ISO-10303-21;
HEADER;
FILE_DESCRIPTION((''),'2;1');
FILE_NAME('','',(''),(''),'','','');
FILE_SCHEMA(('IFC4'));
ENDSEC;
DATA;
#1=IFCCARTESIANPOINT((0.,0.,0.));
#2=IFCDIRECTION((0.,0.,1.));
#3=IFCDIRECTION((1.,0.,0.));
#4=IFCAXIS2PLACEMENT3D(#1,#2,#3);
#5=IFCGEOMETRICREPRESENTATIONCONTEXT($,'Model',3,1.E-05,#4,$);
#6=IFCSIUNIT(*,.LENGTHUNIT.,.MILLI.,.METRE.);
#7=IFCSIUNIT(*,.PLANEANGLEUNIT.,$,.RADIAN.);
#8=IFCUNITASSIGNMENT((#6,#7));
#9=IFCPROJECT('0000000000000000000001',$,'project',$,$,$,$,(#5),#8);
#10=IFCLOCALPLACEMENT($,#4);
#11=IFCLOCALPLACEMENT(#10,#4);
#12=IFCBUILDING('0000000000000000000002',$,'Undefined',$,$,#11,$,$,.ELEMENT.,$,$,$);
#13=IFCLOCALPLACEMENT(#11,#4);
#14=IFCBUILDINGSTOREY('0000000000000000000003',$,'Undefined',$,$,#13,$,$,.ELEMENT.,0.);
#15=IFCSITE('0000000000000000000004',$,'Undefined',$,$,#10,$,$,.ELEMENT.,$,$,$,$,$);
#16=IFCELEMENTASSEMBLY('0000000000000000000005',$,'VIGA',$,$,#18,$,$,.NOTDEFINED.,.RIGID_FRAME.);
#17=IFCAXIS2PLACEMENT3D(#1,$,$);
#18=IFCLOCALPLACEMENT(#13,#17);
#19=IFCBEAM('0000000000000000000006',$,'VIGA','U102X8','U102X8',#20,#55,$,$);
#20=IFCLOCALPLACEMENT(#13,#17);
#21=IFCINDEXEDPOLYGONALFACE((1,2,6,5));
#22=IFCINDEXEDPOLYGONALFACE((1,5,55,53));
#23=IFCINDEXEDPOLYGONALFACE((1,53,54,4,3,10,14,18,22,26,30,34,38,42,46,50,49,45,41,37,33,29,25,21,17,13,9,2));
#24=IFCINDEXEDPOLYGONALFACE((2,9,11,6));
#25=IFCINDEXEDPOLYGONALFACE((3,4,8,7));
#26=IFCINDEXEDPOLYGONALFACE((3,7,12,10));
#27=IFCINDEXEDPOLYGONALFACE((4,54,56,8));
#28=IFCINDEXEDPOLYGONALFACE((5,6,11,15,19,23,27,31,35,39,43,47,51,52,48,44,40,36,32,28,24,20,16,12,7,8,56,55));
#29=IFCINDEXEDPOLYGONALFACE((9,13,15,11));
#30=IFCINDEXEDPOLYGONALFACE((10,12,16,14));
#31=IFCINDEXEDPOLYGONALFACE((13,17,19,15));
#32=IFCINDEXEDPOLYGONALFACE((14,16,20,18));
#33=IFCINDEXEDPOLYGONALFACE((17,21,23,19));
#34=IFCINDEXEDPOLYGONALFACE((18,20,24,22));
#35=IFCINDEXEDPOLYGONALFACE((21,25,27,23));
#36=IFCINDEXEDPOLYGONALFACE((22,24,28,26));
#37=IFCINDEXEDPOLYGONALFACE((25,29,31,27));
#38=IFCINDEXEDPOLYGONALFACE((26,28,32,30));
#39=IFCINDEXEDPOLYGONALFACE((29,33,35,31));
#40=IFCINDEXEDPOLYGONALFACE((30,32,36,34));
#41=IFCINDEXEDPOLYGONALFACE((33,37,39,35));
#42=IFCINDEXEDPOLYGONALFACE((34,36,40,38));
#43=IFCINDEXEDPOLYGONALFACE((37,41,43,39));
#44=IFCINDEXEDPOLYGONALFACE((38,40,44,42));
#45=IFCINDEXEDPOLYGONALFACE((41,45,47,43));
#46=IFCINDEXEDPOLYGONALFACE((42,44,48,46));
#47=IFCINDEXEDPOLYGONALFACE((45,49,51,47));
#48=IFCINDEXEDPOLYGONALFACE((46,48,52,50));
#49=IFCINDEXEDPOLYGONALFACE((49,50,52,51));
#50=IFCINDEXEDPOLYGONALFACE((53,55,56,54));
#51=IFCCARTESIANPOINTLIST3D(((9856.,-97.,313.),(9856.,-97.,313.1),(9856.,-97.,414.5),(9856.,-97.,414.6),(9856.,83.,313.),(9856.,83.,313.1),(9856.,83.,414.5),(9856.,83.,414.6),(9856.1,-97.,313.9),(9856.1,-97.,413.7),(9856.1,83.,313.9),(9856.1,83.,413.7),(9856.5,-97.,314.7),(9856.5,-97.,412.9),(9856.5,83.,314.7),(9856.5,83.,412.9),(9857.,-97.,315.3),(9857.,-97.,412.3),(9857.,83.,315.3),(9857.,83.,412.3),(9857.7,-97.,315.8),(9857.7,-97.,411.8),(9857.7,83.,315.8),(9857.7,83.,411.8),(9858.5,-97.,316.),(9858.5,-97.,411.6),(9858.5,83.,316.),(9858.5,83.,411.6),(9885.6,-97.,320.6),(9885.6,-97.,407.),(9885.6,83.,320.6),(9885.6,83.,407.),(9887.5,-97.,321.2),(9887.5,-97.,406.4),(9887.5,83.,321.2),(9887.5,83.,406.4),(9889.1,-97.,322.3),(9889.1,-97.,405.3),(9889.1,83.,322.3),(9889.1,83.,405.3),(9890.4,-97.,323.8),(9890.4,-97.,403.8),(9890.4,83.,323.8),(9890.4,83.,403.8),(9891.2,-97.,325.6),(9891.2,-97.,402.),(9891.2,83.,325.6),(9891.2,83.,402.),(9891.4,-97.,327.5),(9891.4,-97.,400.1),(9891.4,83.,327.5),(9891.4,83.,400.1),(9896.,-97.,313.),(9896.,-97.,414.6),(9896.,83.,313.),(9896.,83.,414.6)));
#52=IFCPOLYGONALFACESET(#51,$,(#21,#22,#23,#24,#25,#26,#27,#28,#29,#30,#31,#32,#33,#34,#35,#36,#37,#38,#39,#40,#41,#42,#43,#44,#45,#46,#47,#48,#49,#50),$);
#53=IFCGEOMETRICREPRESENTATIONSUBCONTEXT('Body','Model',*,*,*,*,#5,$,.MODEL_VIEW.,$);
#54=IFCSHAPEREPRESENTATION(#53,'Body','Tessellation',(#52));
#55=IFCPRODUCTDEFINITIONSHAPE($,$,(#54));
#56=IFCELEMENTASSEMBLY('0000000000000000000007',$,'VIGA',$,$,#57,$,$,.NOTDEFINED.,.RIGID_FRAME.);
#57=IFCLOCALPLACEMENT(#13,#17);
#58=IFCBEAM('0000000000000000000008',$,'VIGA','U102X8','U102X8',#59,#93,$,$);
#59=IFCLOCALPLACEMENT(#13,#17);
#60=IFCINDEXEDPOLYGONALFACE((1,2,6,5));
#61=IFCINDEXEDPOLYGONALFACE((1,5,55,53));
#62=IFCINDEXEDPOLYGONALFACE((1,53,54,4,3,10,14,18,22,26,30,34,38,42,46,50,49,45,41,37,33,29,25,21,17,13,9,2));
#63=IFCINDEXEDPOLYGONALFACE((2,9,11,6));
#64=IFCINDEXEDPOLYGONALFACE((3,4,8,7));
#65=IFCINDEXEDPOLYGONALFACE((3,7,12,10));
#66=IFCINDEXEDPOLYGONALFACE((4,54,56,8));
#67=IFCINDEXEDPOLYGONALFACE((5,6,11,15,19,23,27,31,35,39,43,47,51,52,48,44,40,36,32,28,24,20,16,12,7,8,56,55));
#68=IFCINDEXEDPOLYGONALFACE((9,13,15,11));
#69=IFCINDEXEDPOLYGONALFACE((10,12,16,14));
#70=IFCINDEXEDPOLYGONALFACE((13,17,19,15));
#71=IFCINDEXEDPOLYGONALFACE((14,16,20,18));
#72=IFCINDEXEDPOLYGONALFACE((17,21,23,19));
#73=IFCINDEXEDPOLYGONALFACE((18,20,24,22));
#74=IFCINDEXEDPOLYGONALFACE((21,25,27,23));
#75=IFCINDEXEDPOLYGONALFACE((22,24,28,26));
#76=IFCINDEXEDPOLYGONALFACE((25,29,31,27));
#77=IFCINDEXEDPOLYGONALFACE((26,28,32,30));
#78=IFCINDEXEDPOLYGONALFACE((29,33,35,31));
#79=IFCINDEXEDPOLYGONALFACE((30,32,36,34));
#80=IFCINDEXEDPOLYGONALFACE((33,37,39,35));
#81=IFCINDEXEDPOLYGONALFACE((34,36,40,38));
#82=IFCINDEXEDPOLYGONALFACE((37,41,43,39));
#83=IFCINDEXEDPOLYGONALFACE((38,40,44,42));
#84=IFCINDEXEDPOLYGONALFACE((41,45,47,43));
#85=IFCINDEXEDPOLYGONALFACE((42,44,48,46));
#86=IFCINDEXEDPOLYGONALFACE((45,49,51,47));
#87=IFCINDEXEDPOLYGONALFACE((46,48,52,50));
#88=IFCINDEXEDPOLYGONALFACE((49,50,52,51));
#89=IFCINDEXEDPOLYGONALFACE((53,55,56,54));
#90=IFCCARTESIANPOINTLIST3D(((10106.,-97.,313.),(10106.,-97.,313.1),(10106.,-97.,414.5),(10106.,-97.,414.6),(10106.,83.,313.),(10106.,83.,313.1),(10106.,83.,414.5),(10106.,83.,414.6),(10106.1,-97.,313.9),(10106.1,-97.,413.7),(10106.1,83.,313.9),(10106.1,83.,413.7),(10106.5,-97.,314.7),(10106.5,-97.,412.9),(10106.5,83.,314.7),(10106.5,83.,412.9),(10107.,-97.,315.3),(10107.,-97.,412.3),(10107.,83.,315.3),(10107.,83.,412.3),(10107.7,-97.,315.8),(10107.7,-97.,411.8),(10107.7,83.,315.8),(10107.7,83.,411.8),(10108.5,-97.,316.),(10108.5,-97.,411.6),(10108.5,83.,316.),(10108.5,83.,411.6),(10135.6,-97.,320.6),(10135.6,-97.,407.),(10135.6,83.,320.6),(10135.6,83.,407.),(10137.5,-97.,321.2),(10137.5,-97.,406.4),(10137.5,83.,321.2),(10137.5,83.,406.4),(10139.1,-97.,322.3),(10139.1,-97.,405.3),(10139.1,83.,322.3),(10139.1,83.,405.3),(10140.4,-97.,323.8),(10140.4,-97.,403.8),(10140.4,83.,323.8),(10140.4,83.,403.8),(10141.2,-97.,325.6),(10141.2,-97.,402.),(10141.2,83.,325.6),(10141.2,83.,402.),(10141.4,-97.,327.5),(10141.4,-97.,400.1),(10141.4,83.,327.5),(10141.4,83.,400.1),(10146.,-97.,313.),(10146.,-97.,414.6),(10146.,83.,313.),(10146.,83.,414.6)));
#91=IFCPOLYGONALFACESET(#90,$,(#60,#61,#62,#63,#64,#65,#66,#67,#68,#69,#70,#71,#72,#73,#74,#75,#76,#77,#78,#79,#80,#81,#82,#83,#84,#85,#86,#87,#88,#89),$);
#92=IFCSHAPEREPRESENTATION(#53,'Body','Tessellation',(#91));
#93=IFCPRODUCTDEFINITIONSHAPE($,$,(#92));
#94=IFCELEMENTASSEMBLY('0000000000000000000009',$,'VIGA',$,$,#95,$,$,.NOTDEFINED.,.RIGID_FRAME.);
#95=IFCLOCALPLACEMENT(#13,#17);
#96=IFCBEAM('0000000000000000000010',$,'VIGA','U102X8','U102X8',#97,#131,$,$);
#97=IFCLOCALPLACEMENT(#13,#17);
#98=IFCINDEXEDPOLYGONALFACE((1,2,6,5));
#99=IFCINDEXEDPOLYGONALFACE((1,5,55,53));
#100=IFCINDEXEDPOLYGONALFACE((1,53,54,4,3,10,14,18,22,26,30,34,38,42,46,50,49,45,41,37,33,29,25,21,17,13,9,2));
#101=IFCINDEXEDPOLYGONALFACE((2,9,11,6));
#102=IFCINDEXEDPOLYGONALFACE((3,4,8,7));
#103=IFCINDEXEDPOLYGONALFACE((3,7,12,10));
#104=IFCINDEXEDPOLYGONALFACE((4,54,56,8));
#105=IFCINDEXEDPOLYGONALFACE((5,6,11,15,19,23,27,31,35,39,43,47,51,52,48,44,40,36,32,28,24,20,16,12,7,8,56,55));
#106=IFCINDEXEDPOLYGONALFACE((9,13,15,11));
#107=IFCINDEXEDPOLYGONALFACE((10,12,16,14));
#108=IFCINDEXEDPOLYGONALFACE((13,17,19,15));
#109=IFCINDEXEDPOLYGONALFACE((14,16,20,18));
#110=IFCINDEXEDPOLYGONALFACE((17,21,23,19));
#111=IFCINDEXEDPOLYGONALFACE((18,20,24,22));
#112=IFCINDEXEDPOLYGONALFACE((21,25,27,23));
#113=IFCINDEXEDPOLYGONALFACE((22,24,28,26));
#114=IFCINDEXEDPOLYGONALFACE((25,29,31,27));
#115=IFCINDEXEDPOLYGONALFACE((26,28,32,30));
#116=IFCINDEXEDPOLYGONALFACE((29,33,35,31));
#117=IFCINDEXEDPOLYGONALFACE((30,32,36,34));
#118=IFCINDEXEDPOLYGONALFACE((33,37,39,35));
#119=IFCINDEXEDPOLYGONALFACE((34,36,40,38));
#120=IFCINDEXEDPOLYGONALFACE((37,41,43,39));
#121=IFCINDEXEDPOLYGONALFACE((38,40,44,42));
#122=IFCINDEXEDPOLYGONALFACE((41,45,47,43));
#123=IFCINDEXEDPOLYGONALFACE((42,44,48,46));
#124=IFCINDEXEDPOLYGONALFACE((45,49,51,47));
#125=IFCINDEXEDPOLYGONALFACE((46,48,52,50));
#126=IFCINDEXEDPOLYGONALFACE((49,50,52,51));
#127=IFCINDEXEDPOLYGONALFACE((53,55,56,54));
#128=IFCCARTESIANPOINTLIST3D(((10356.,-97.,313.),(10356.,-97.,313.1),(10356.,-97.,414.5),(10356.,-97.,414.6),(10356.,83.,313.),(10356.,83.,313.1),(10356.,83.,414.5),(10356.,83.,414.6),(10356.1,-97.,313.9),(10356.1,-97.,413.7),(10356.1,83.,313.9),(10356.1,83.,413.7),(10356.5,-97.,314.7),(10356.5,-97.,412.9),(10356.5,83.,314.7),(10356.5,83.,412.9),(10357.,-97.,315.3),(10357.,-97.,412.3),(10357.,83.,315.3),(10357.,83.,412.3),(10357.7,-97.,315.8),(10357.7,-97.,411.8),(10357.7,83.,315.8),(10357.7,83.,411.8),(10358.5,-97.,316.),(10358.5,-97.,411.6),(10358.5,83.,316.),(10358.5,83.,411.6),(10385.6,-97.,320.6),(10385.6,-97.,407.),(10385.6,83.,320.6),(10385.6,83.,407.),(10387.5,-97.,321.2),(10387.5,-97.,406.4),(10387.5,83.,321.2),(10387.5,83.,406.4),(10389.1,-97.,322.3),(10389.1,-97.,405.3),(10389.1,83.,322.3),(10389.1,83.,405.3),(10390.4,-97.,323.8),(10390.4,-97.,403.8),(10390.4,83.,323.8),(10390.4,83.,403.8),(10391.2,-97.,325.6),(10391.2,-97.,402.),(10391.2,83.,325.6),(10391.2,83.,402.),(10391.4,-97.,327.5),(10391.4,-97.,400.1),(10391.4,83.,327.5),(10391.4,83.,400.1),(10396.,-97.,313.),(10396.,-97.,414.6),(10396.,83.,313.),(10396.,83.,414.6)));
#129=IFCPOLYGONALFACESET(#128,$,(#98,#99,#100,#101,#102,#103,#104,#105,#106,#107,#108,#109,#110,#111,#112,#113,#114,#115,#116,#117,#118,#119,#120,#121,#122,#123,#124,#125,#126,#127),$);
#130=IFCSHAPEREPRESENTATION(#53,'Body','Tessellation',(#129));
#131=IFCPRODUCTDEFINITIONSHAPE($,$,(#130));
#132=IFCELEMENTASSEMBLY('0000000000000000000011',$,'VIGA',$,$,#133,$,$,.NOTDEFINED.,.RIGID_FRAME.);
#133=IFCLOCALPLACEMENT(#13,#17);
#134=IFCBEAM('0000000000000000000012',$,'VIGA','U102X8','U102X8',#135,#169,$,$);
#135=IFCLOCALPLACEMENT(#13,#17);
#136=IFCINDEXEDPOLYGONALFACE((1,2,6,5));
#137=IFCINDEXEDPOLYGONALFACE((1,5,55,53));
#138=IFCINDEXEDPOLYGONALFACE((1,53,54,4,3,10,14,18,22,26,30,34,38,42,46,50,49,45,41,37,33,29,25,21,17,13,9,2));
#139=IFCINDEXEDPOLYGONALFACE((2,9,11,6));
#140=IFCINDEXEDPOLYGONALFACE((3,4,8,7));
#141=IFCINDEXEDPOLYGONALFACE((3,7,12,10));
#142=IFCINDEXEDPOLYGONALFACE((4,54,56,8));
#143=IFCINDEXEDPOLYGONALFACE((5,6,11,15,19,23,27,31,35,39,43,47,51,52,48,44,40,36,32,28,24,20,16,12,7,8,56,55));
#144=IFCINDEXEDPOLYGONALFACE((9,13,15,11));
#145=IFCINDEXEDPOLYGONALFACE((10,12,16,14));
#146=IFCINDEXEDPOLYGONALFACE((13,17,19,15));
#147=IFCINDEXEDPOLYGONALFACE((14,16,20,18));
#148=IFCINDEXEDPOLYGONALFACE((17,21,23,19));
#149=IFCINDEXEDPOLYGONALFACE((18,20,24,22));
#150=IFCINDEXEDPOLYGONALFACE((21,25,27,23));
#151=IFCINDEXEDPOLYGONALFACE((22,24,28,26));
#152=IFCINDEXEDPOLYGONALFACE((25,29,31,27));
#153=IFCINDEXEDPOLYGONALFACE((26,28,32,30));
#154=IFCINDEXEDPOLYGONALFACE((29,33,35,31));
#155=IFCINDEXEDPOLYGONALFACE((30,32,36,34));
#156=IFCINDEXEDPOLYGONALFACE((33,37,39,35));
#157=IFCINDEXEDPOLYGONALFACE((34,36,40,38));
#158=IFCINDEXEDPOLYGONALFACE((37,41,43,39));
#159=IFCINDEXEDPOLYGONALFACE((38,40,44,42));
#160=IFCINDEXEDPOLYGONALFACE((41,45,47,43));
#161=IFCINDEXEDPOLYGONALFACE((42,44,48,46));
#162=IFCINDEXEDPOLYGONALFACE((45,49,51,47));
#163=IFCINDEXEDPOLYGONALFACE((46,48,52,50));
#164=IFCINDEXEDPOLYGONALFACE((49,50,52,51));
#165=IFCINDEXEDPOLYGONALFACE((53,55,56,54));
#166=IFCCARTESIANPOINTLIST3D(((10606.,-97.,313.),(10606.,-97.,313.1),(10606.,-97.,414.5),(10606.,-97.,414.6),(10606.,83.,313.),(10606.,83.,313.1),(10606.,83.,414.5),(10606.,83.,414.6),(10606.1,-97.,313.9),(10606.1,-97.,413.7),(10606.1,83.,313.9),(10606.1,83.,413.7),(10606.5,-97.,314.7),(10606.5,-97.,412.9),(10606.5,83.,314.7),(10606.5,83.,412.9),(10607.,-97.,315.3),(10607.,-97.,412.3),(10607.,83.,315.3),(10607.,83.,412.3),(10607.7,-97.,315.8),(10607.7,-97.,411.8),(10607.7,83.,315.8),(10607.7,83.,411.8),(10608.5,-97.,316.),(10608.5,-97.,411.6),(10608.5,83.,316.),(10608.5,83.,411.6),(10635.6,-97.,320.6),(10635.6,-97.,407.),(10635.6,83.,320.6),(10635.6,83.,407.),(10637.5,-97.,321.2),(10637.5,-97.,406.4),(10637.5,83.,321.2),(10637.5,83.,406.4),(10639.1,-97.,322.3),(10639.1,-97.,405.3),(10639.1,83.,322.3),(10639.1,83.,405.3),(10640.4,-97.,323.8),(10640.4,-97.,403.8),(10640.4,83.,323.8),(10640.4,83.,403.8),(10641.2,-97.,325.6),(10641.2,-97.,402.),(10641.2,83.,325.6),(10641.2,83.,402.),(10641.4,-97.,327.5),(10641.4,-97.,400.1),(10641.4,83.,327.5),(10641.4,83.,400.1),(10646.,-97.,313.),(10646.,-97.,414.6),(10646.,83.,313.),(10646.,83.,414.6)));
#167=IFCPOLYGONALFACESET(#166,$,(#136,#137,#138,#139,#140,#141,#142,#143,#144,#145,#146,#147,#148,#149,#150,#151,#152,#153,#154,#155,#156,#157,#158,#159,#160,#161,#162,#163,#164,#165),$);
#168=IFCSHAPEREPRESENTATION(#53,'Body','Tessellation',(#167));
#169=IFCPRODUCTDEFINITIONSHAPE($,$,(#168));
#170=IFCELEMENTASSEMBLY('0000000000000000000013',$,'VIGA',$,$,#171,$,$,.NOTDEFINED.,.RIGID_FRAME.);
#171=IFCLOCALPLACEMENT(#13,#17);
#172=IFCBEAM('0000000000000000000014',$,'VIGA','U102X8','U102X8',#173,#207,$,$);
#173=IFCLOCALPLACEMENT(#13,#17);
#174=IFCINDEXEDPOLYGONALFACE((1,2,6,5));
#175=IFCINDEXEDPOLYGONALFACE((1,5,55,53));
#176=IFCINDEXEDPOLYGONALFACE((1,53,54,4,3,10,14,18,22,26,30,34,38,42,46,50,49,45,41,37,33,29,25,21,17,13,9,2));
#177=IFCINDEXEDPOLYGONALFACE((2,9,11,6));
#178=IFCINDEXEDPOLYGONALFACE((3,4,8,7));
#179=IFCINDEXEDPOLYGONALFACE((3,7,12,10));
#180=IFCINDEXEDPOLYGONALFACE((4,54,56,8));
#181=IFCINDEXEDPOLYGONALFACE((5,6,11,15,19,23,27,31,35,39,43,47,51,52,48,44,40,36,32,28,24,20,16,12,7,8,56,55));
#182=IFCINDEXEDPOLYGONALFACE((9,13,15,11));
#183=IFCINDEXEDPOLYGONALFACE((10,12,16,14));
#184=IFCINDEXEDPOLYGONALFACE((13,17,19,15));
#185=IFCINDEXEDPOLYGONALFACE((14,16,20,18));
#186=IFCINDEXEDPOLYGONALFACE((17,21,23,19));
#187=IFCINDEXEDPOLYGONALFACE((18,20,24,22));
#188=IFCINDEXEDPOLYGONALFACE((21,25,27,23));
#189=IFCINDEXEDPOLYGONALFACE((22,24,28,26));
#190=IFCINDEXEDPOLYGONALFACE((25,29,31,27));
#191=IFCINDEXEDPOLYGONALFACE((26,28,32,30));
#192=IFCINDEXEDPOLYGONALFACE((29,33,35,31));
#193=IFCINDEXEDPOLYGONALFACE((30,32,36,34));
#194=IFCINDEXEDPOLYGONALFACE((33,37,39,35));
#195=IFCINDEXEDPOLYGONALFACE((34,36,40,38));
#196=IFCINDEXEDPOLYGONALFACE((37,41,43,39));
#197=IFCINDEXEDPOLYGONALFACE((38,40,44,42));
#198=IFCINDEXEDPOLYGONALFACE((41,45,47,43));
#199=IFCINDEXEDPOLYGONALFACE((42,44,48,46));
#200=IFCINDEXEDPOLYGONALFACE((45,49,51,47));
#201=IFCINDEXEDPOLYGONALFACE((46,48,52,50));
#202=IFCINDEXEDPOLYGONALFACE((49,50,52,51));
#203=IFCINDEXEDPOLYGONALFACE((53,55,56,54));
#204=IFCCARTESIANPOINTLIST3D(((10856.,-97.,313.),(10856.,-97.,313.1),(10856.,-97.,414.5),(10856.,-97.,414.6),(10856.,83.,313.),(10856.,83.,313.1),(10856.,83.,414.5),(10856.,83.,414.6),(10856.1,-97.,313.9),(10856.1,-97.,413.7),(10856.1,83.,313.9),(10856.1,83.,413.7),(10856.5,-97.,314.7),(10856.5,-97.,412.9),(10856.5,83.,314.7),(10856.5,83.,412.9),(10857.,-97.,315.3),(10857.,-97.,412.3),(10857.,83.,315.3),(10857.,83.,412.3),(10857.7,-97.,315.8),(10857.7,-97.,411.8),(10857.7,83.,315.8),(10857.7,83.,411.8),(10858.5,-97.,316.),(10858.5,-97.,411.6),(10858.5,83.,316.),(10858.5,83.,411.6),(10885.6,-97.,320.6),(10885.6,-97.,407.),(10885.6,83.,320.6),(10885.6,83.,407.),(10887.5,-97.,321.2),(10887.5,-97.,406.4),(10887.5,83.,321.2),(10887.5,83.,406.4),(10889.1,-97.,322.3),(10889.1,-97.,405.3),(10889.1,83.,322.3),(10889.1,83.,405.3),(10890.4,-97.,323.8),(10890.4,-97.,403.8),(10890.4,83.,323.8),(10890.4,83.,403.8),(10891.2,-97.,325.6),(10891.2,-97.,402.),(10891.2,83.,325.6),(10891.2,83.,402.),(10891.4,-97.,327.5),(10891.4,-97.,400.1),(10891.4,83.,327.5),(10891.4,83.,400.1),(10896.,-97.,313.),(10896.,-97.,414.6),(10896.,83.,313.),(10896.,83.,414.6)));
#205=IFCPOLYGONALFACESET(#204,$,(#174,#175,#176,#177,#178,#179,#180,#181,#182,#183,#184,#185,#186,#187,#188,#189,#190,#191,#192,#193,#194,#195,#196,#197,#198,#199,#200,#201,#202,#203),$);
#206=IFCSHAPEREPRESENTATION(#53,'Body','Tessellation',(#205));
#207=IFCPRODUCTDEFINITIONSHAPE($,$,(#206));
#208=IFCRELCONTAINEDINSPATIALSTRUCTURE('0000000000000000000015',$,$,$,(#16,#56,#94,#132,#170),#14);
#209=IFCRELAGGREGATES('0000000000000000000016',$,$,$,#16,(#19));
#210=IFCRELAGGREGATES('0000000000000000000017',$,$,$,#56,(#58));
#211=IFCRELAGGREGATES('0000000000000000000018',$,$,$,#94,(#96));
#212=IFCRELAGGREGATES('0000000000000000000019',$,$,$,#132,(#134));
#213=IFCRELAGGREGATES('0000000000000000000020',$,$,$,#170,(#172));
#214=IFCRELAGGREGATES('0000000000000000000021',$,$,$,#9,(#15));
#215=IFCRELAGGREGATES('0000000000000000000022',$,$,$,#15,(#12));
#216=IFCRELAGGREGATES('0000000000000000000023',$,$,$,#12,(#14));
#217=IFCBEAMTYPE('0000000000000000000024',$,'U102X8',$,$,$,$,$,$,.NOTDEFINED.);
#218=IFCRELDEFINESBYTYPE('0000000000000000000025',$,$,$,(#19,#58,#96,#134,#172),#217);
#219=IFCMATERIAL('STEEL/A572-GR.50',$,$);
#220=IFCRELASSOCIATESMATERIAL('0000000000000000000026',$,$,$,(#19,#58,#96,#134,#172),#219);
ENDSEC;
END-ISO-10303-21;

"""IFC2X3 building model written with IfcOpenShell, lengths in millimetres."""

from ifc_helpers import new_model, si_unit, frame, origin_with_axes, origin_2d_with_axis, place, context, subcontext, project, spatial, u_section, extrude, material, type_object, element, aggregate, save


model = new_model("IFC2X3")

# Units and contexts
model_context = context("Model", 3, precision=1e-05, world=origin_with_axes())
body_context = subcontext(model_context, "Body", "Model", "MODEL_VIEW")
ifc_project = project(units=[si_unit("LENGTHUNIT", "METRE", prefix="MILLI"), si_unit("PLANEANGLEUNIT", "RADIAN")], contexts=[model_context])

# Site, building, storey
site_placement = place(None, origin_with_axes())
site = spatial("IfcSite", under=ifc_project, at=site_placement, Name="Undefined", CompositionType="ELEMENT")
building_placement = place(site_placement, origin_with_axes())
building = spatial("IfcBuilding", under=site, at=building_placement, Name="Undefined", CompositionType="ELEMENT")
storey_placement = place(building_placement, origin_with_axes())
storey = spatial("IfcBuildingStorey", under=building, at=storey_placement, Name="Undefined", CompositionType="ELEMENT", Elevation=0.0)

# Element assemblies, beams
ifc_material_1 = material(Name="STEEL/A572-GR.50")
beam_type = type_object("IfcBeamType", Name="U102X8", PredefinedType="NOTDEFINED")
assembly_1_placement = place(storey_placement, origin_with_axes())
assembly_1 = element("IfcElementAssembly", 1, at=assembly_1_placement, inside=storey, Name="VIGA", AssemblyPlace="NOTDEFINED", PredefinedType="RIGID_FRAME")
beam_1_placement = place(assembly_1_placement, frame((9876.0, 83.0, 363.8), z_axis=(0.0, 0.0, 1.0), x_axis=(0.0, -1.0, 0.0)))
beam_1 = element("IfcBeam", 2, at=beam_1_placement, type_object=beam_type, material=ifc_material_1, Name="VIGA", Description="U102X8", ObjectType="U102X8", context=body_context, shape_type="SweptSolid", body=[
    extrude(u_section(Depth=101.6, FlangeWidth=40.0, WebThickness=4.6, FlangeThickness=6.0, FilletRadius=7.0, EdgeRadius=3.0, FlangeSlope=0.16839, at=origin_2d_with_axis()), frame((180.0, 0.0, 0.0), z_axis=(-1.0, 0.0, 0.0), x_axis=(0.0, -1.0, 0.0)), (0.0, 0.0, 1.0), 180.0),
])
aggregate(assembly_1, [beam_1])
assembly_2_placement = place(storey_placement, origin_with_axes())
assembly_2 = element("IfcElementAssembly", 3, at=assembly_2_placement, inside=storey, Name="VIGA", AssemblyPlace="NOTDEFINED", PredefinedType="RIGID_FRAME")
beam_2_placement = place(assembly_2_placement, frame((10126.0, 83.0, 363.8), z_axis=(0.0, 0.0, 1.0), x_axis=(0.0, -1.0, 0.0)))
beam_2 = element("IfcBeam", 4, at=beam_2_placement, type_object=beam_type, material=ifc_material_1, Name="VIGA", Description="U102X8", ObjectType="U102X8", context=body_context, shape_type="SweptSolid", body=[
    extrude(u_section(Depth=101.6, FlangeWidth=40.0, WebThickness=4.6, FlangeThickness=6.0, FilletRadius=7.0, EdgeRadius=3.0, FlangeSlope=0.16839, at=origin_2d_with_axis()), frame((180.0, 0.0, 0.0), z_axis=(-1.0, 0.0, 0.0), x_axis=(0.0, -1.0, 0.0)), (0.0, 0.0, 1.0), 180.0),
])
aggregate(assembly_2, [beam_2])
assembly_3_placement = place(storey_placement, origin_with_axes())
assembly_3 = element("IfcElementAssembly", 5, at=assembly_3_placement, inside=storey, Name="VIGA", AssemblyPlace="NOTDEFINED", PredefinedType="RIGID_FRAME")
beam_3_placement = place(assembly_3_placement, frame((10376.0, 83.0, 363.8), z_axis=(0.0, 0.0, 1.0), x_axis=(0.0, -1.0, 0.0)))
beam_3 = element("IfcBeam", 6, at=beam_3_placement, type_object=beam_type, material=ifc_material_1, Name="VIGA", Description="U102X8", ObjectType="U102X8", context=body_context, shape_type="SweptSolid", body=[
    extrude(u_section(Depth=101.6, FlangeWidth=40.0, WebThickness=4.6, FlangeThickness=6.0, FilletRadius=7.0, EdgeRadius=3.0, FlangeSlope=0.16839, at=origin_2d_with_axis()), frame((180.0, 0.0, 0.0), z_axis=(-1.0, 0.0, 0.0), x_axis=(0.0, -1.0, 0.0)), (0.0, 0.0, 1.0), 180.0),
])
aggregate(assembly_3, [beam_3])
assembly_4_placement = place(storey_placement, origin_with_axes())
assembly_4 = element("IfcElementAssembly", 7, at=assembly_4_placement, inside=storey, Name="VIGA", AssemblyPlace="NOTDEFINED", PredefinedType="RIGID_FRAME")
beam_4_placement = place(assembly_4_placement, frame((10626.0, 83.0, 363.8), z_axis=(0.0, 0.0, 1.0), x_axis=(0.0, -1.0, 0.0)))
beam_4 = element("IfcBeam", 8, at=beam_4_placement, type_object=beam_type, material=ifc_material_1, Name="VIGA", Description="U102X8", ObjectType="U102X8", context=body_context, shape_type="SweptSolid", body=[
    extrude(u_section(Depth=101.6, FlangeWidth=40.0, WebThickness=4.6, FlangeThickness=6.0, FilletRadius=7.0, EdgeRadius=3.0, FlangeSlope=0.16839, at=origin_2d_with_axis()), frame((180.0, 0.0, 0.0), z_axis=(-1.0, 0.0, 0.0), x_axis=(0.0, -1.0, 0.0)), (0.0, 0.0, 1.0), 180.0),
])
aggregate(assembly_4, [beam_4])
assembly_5_placement = place(storey_placement, origin_with_axes())
assembly_5 = element("IfcElementAssembly", 9, at=assembly_5_placement, inside=storey, Name="VIGA", AssemblyPlace="NOTDEFINED", PredefinedType="RIGID_FRAME")
beam_5_placement = place(assembly_5_placement, frame((10876.0, 83.0, 363.8), z_axis=(0.0, 0.0, 1.0), x_axis=(0.0, -1.0, 0.0)))
beam_5 = element("IfcBeam", 10, at=beam_5_placement, type_object=beam_type, material=ifc_material_1, Name="VIGA", Description="U102X8", ObjectType="U102X8", context=body_context, shape_type="SweptSolid", body=[
    extrude(u_section(Depth=101.6, FlangeWidth=40.0, WebThickness=4.6, FlangeThickness=6.0, FilletRadius=7.0, EdgeRadius=3.0, FlangeSlope=0.16839, at=origin_2d_with_axis()), frame((180.0, 0.0, 0.0), z_axis=(-1.0, 0.0, 0.0), x_axis=(0.0, -1.0, 0.0)), (0.0, 0.0, 1.0), 180.0),
])
aggregate(assembly_5, [beam_5])

save(model, "model.ifc")
